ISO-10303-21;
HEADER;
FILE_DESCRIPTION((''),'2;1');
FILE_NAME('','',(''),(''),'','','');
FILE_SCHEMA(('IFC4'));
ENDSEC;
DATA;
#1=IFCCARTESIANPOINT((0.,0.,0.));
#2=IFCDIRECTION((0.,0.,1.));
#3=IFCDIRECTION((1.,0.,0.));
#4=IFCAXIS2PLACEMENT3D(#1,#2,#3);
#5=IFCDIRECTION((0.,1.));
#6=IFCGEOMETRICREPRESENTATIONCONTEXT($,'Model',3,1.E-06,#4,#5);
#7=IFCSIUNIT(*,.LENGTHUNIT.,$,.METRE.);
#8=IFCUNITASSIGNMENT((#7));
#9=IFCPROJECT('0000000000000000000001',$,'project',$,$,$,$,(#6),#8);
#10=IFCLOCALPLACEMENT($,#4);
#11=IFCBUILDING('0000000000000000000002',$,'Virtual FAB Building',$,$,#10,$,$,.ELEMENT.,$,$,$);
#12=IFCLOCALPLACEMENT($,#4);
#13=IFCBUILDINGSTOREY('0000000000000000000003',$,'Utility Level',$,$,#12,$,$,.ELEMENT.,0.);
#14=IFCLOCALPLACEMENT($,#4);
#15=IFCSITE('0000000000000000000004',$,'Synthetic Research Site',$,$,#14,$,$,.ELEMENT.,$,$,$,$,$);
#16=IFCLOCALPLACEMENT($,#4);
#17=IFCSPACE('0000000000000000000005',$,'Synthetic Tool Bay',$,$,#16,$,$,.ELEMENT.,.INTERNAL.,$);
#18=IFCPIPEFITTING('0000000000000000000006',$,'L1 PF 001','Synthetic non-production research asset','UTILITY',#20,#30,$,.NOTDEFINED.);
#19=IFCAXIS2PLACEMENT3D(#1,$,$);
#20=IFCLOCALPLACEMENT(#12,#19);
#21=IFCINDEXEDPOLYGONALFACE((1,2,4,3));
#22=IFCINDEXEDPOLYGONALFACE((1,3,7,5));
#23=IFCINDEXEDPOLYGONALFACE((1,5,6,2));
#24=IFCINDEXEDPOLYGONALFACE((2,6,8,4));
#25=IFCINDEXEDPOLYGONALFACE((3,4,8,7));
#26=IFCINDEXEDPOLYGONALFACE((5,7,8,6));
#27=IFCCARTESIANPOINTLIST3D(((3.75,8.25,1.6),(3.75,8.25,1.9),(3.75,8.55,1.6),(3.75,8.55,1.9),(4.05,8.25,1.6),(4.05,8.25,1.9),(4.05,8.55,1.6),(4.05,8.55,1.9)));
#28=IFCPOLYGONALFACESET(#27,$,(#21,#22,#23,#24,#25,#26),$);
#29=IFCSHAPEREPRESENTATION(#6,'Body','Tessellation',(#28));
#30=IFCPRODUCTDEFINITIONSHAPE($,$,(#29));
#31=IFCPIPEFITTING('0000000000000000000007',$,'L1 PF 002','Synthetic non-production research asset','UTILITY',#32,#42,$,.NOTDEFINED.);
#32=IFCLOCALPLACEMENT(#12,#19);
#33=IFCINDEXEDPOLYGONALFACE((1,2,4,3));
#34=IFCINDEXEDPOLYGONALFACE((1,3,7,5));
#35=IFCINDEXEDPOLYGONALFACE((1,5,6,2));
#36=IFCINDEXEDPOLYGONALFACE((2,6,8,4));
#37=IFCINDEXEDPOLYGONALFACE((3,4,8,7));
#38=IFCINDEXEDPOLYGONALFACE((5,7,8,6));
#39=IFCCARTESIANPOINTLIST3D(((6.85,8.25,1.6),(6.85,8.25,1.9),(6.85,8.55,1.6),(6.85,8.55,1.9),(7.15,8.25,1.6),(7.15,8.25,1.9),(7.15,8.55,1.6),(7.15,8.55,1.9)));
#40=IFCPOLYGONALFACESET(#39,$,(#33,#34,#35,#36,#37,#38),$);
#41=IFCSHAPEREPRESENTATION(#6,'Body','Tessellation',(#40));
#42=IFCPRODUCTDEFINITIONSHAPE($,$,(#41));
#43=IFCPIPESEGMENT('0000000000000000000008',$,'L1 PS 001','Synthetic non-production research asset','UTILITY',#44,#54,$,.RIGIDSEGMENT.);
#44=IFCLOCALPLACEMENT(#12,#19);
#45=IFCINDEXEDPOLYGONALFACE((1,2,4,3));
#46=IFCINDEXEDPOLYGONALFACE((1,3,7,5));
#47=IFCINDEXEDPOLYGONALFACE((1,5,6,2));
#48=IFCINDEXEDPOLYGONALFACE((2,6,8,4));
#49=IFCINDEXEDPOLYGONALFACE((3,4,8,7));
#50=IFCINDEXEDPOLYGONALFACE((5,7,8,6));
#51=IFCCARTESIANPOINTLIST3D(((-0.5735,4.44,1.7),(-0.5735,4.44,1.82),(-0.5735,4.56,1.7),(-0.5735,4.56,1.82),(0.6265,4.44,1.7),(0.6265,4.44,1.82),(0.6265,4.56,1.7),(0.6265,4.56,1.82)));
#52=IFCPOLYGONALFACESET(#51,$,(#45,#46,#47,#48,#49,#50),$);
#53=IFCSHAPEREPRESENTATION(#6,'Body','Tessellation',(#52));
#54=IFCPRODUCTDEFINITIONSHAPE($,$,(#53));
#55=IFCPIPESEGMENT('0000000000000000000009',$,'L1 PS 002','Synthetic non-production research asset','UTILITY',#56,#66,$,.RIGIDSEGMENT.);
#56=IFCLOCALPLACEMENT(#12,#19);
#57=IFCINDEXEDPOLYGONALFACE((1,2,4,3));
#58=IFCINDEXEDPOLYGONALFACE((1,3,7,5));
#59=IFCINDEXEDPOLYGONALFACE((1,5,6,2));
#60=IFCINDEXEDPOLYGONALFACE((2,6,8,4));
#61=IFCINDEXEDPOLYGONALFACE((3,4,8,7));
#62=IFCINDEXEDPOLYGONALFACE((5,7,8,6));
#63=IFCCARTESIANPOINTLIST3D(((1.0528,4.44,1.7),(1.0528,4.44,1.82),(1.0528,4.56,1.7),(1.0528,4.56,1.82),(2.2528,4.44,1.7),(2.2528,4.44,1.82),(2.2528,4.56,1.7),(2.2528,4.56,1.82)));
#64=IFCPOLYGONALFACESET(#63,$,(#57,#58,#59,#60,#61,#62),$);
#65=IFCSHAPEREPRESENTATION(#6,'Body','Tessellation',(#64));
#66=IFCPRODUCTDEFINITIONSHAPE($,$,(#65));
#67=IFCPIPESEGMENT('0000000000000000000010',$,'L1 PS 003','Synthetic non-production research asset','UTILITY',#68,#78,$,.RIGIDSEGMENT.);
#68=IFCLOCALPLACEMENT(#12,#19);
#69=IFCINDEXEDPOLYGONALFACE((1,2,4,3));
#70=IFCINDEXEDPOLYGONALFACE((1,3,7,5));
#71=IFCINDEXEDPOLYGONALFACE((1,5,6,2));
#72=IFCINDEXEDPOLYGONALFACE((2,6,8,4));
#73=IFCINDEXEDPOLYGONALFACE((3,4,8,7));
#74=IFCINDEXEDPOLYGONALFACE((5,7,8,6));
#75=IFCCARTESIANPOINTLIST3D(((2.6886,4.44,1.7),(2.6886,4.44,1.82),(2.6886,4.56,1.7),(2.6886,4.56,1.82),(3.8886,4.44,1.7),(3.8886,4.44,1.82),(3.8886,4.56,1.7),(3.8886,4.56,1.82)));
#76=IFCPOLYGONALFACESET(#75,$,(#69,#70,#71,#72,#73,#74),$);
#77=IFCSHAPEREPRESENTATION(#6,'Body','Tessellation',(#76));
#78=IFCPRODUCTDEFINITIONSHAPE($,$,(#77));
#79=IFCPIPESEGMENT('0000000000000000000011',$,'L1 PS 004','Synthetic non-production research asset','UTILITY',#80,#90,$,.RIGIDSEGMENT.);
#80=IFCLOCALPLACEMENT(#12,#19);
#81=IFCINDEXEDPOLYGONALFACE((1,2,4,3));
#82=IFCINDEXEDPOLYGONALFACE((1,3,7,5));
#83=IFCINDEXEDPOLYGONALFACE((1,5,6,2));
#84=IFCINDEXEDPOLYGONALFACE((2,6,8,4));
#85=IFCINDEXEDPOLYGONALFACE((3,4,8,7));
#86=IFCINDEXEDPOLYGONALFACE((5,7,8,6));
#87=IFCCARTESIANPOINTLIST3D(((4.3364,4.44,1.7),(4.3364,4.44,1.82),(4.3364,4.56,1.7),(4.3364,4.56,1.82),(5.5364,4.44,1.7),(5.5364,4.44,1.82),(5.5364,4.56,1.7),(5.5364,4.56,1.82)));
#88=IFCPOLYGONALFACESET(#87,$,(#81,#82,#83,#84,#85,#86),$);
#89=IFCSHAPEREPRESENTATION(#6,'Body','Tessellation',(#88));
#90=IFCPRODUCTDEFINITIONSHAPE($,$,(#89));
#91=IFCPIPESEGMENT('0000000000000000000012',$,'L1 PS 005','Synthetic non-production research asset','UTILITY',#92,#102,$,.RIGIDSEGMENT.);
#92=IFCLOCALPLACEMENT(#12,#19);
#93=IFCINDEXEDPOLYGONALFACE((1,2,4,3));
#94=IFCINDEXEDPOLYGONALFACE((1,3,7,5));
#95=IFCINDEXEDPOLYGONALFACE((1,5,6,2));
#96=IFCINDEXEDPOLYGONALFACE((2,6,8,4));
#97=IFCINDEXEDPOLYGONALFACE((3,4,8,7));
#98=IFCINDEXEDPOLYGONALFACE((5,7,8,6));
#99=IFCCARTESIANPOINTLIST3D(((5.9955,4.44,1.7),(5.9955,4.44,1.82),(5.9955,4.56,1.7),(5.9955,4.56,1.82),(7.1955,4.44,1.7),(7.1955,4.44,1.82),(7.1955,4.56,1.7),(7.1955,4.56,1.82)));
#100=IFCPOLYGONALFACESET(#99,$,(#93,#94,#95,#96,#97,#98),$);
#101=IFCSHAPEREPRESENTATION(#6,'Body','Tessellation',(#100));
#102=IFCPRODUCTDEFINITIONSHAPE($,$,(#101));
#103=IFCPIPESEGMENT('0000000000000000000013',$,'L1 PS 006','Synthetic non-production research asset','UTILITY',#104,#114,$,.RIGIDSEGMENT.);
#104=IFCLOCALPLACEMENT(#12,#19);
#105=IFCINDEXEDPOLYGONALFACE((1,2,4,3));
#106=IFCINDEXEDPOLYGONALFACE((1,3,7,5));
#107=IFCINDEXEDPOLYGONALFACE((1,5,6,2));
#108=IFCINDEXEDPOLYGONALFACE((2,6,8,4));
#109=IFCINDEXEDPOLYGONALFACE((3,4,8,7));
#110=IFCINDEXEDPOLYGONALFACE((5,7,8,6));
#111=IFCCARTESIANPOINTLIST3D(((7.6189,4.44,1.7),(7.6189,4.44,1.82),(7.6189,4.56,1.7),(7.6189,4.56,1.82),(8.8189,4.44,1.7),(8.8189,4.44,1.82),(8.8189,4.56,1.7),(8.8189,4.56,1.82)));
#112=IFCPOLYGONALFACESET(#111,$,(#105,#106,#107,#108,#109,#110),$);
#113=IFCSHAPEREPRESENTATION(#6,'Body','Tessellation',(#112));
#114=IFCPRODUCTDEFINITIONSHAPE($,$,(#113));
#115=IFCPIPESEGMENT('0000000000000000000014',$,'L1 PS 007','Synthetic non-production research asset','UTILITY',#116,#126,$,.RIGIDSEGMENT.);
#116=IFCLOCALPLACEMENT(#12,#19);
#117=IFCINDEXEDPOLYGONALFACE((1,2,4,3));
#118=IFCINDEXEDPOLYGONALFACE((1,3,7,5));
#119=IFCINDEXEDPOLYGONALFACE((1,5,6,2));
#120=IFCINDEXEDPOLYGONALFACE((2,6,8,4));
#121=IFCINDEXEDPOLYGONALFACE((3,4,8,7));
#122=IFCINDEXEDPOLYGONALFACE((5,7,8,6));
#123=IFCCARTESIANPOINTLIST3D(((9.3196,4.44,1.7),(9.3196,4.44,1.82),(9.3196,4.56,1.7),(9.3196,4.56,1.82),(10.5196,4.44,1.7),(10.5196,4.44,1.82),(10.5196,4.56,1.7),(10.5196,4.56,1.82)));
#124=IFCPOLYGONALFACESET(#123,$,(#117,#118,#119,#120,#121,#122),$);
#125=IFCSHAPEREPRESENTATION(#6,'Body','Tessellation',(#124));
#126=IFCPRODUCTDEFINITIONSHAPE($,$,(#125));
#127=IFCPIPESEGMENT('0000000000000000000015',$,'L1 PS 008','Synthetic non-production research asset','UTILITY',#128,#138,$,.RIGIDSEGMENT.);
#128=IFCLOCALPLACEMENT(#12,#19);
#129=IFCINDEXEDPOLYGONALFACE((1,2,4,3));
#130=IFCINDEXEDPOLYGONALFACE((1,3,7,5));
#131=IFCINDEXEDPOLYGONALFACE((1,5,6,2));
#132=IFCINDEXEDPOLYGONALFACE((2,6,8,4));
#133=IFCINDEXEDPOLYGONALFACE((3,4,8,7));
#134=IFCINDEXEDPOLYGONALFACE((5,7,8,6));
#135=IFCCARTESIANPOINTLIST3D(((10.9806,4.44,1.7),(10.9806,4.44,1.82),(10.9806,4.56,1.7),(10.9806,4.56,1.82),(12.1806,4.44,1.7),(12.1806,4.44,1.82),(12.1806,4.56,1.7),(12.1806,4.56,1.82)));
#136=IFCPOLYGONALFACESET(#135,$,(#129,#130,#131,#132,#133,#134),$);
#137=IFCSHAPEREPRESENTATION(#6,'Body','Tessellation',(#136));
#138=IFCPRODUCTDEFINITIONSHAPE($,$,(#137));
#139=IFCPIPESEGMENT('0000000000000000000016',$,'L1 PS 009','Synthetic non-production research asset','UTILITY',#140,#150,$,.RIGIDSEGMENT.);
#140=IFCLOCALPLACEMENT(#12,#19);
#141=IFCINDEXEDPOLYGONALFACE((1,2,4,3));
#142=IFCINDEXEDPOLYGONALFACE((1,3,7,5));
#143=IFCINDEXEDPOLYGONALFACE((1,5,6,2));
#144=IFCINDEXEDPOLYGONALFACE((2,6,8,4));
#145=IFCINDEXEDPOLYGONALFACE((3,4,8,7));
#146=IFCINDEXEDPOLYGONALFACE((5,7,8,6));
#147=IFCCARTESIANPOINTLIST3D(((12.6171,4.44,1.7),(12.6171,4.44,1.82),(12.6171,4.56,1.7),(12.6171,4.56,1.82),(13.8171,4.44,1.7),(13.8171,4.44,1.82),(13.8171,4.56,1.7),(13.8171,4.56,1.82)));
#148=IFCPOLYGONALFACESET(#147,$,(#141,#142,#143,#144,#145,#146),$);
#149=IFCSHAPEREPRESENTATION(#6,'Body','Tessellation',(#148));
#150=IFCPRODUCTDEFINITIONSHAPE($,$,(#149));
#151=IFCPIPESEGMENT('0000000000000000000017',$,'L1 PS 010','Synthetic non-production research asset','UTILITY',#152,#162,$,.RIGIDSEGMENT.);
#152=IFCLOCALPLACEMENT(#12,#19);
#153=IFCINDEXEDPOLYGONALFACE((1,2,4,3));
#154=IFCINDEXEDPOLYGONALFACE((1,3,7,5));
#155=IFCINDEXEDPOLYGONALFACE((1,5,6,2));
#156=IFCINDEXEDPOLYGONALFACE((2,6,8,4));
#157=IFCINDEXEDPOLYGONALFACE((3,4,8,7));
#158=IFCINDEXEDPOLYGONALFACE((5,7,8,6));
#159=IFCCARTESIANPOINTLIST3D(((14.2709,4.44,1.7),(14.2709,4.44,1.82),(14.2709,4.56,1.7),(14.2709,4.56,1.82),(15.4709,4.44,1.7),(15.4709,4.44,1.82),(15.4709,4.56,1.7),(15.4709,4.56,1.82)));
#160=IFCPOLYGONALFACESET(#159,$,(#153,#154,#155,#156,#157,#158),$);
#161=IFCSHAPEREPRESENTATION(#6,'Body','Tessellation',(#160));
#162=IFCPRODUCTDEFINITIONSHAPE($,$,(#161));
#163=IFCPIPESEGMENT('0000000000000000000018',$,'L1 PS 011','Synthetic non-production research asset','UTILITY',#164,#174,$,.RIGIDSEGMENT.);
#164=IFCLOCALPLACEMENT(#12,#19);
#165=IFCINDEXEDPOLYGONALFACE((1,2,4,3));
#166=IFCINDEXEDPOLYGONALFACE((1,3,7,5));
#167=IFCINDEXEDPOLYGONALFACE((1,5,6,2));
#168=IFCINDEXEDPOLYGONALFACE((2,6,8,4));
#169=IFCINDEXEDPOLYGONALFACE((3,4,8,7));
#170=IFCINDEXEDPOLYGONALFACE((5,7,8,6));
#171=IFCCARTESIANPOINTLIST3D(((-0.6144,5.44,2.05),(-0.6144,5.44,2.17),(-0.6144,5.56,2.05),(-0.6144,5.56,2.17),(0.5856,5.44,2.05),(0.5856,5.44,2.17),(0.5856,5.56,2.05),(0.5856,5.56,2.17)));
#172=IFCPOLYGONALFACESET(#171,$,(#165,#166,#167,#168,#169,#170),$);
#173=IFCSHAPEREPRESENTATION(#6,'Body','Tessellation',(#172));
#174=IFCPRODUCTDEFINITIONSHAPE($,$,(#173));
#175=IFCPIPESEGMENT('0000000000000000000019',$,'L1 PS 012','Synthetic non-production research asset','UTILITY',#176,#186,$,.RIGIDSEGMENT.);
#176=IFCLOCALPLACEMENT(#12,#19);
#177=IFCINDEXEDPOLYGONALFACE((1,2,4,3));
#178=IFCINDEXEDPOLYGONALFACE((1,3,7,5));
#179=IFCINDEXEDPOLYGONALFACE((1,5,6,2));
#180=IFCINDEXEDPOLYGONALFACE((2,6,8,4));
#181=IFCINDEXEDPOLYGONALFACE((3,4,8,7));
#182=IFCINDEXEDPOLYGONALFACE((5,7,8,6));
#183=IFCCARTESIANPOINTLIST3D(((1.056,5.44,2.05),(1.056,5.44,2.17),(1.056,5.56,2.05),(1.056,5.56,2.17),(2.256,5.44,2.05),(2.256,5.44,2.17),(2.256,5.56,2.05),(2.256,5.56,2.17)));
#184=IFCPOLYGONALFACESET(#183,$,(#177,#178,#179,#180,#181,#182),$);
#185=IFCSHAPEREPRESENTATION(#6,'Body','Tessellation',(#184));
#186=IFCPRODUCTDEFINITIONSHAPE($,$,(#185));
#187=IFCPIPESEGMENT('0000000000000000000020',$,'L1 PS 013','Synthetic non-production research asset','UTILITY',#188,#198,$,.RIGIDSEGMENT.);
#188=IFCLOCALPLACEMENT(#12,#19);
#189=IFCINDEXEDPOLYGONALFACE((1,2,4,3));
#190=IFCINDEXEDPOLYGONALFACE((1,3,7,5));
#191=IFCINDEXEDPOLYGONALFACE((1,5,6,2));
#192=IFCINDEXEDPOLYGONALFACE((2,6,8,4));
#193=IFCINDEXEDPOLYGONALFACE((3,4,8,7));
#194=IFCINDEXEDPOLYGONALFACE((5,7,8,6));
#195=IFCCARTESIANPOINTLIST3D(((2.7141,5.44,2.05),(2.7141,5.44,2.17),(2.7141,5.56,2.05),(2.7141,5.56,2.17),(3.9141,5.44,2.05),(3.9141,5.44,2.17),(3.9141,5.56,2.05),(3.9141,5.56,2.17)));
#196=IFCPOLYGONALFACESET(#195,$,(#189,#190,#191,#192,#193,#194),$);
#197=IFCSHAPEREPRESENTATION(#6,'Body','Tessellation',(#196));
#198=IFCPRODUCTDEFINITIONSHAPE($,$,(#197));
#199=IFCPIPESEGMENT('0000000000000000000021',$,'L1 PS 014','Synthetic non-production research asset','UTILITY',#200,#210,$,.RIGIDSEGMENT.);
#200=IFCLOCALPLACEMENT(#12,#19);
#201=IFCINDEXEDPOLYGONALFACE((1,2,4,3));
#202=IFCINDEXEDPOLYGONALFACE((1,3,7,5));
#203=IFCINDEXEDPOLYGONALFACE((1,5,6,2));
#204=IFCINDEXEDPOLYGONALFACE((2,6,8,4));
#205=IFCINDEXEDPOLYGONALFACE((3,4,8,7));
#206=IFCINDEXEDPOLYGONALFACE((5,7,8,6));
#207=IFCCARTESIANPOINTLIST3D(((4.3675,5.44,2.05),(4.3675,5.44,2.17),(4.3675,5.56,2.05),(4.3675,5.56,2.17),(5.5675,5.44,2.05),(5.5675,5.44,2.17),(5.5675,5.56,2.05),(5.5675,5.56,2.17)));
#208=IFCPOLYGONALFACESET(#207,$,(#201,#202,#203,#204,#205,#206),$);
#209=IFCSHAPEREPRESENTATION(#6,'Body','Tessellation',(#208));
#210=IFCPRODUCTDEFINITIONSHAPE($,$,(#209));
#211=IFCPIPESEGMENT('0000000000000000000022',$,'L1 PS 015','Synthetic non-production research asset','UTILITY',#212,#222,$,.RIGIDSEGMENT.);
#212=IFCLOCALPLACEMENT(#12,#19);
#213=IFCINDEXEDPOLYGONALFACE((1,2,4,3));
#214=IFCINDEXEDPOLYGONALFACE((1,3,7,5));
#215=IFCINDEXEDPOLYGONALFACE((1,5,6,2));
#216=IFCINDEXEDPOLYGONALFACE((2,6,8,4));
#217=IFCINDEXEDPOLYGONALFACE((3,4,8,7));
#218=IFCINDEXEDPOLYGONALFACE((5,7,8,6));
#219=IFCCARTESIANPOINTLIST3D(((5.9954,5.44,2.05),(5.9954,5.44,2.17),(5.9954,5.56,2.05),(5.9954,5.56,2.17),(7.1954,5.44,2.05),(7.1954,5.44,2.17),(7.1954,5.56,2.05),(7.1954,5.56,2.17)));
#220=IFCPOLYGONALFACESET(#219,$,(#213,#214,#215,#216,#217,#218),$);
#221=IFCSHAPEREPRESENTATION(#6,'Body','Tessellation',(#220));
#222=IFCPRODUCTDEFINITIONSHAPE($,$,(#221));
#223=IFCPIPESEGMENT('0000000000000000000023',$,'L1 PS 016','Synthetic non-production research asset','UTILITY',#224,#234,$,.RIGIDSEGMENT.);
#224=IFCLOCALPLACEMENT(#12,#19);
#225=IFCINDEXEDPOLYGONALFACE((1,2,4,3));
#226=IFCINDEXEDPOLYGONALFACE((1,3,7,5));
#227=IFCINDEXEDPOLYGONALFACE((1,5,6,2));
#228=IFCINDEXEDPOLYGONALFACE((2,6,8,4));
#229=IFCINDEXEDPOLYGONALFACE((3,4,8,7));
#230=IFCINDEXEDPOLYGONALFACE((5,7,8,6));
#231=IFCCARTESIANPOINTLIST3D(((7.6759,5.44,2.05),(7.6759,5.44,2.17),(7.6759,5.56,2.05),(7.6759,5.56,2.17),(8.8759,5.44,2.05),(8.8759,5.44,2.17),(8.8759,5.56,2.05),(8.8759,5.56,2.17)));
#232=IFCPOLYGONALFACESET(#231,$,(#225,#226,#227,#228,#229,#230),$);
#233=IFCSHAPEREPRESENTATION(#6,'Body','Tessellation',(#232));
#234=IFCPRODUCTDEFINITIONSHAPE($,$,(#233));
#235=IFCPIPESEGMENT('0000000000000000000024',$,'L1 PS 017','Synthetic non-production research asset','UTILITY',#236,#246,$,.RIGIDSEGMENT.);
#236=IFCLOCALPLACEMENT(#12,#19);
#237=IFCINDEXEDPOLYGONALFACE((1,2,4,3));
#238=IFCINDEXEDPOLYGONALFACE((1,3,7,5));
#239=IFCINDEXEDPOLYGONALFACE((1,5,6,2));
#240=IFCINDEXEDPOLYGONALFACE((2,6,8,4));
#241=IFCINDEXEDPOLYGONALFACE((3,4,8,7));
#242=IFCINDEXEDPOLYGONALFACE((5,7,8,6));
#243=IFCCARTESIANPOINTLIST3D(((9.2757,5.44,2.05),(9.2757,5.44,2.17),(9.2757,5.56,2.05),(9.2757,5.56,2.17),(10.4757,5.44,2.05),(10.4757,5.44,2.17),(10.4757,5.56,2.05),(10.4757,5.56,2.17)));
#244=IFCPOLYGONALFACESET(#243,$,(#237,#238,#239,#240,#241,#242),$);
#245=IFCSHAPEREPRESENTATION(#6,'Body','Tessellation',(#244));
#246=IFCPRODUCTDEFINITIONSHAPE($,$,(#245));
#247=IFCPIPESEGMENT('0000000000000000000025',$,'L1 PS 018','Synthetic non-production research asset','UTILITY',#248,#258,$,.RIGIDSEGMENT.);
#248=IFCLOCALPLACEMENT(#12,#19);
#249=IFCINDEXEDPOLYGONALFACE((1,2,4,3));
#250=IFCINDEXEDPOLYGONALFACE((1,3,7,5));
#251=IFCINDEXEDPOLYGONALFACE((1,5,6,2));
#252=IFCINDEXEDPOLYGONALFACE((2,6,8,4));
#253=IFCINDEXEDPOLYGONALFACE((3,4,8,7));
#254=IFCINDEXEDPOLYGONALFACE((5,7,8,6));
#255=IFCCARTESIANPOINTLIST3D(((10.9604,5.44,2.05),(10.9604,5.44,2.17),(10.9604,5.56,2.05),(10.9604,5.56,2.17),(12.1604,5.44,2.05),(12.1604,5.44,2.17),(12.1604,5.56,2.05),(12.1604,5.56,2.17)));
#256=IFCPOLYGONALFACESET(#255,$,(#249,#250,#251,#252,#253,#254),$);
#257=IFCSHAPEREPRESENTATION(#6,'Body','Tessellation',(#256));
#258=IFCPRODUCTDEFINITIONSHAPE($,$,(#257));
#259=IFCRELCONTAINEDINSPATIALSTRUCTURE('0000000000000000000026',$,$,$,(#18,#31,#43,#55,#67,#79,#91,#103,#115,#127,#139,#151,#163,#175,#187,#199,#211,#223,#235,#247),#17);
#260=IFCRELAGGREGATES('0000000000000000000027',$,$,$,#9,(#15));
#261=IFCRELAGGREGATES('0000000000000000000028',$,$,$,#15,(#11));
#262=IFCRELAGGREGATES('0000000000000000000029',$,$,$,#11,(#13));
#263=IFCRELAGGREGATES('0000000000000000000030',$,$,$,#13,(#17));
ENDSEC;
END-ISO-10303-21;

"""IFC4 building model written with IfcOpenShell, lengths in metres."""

from ifc_helpers import new_model, si_unit, direction, frame, origin_with_axes, origin_2d_with_axis, place, context, project, spatial, rectangle, extrude, element, save


model = new_model("IFC4")

# Units and contexts
model_context = context("Model", 3, precision=1e-06, world=origin_with_axes(), true_north=direction((0.0, 1.0)))
ifc_project = project(units=[si_unit("LENGTHUNIT", "METRE")], contexts=[model_context])

# Site, building, storey, space
site_placement = place(None, origin_with_axes())
site = spatial("IfcSite", under=ifc_project, at=site_placement, Name="Synthetic Research Site", CompositionType="ELEMENT")
building_placement = place(None, origin_with_axes())
building = spatial("IfcBuilding", under=site, at=building_placement, Name="Virtual FAB Building", CompositionType="ELEMENT")
storey_placement = place(None, origin_with_axes())
storey = spatial("IfcBuildingStorey", under=building, at=storey_placement, Name="Utility Level", CompositionType="ELEMENT", Elevation=0.0)
space_placement = place(None, origin_with_axes())
space = spatial("IfcSpace", under=storey, at=space_placement, Name="Synthetic Tool Bay", CompositionType="ELEMENT", PredefinedType="INTERNAL")

# Pipe fittings
for number, where, z_axis, x_axis, name in (
    (1, (3.9, 8.4, 1.6), (0.0, 0.0, 1.0), (1.0, 0.0, 0.0), "L1 PF 001"),
    (2, (7.0, 8.4, 1.6), (0.0, 0.0, 1.0), (1.0, 0.0, 0.0), "L1 PF 002"),
):
    element("IfcPipeFitting", number, at=place(None, frame(where, z_axis=z_axis, x_axis=x_axis)), inside=space, Name=name, Description="Synthetic non-production research asset", ObjectType="UTILITY", PredefinedType="NOTDEFINED", context=model_context, shape_type="SweptSolid", body=[
        extrude(rectangle(XDim=0.3, YDim=0.3, at=origin_2d_with_axis()), origin_with_axes(), (0.0, 0.0, 1.0), 0.3),
    ])

# Pipe segments
for number, where, z_axis, x_axis, name in (
    (3, (0.0265, 4.5, 1.7), (0.0, 0.0, 1.0), (1.0, 0.0, 0.0), "L1 PS 001"),
    (4, (1.6528, 4.5, 1.7), (0.0, 0.0, 1.0), (1.0, 0.0, 0.0), "L1 PS 002"),
    (5, (3.2886, 4.5, 1.7), (0.0, 0.0, 1.0), (1.0, 0.0, 0.0), "L1 PS 003"),
    (6, (4.9364, 4.5, 1.7), (0.0, 0.0, 1.0), (1.0, 0.0, 0.0), "L1 PS 004"),
    (7, (6.5955, 4.5, 1.7), (0.0, 0.0, 1.0), (1.0, 0.0, 0.0), "L1 PS 005"),
    (8, (8.2189, 4.5, 1.7), (0.0, 0.0, 1.0), (1.0, 0.0, 0.0), "L1 PS 006"),
    (9, (9.9196, 4.5, 1.7), (0.0, 0.0, 1.0), (1.0, 0.0, 0.0), "L1 PS 007"),
    (10, (11.5806, 4.5, 1.7), (0.0, 0.0, 1.0), (1.0, 0.0, 0.0), "L1 PS 008"),
    (11, (13.2171, 4.5, 1.7), (0.0, 0.0, 1.0), (1.0, 0.0, 0.0), "L1 PS 009"),
    (12, (14.8709, 4.5, 1.7), (0.0, 0.0, 1.0), (1.0, 0.0, 0.0), "L1 PS 010"),
    (13, (-0.0144, 5.5, 2.05), (0.0, 0.0, 1.0), (1.0, 0.0, 0.0), "L1 PS 011"),
    (14, (1.656, 5.5, 2.05), (0.0, 0.0, 1.0), (1.0, 0.0, 0.0), "L1 PS 012"),
    (15, (3.3141, 5.5, 2.05), (0.0, 0.0, 1.0), (1.0, 0.0, 0.0), "L1 PS 013"),
    (16, (4.9675, 5.5, 2.05), (0.0, 0.0, 1.0), (1.0, 0.0, 0.0), "L1 PS 014"),
    (17, (6.5954, 5.5, 2.05), (0.0, 0.0, 1.0), (1.0, 0.0, 0.0), "L1 PS 015"),
    (18, (8.2759, 5.5, 2.05), (0.0, 0.0, 1.0), (1.0, 0.0, 0.0), "L1 PS 016"),
    (19, (9.8757, 5.5, 2.05), (0.0, 0.0, 1.0), (1.0, 0.0, 0.0), "L1 PS 017"),
    (20, (11.5604, 5.5, 2.05), (0.0, 0.0, 1.0), (1.0, 0.0, 0.0), "L1 PS 018"),
):
    element("IfcPipeSegment", number, at=place(None, frame(where, z_axis=z_axis, x_axis=x_axis)), inside=space, Name=name, Description="Synthetic non-production research asset", ObjectType="UTILITY", PredefinedType="RIGIDSEGMENT", context=model_context, shape_type="SweptSolid", body=[
        extrude(rectangle(XDim=1.2, YDim=0.12, at=origin_2d_with_axis()), origin_with_axes(), (0.0, 0.0, 1.0), 0.12),
    ])

save(model, "model.ifc")
